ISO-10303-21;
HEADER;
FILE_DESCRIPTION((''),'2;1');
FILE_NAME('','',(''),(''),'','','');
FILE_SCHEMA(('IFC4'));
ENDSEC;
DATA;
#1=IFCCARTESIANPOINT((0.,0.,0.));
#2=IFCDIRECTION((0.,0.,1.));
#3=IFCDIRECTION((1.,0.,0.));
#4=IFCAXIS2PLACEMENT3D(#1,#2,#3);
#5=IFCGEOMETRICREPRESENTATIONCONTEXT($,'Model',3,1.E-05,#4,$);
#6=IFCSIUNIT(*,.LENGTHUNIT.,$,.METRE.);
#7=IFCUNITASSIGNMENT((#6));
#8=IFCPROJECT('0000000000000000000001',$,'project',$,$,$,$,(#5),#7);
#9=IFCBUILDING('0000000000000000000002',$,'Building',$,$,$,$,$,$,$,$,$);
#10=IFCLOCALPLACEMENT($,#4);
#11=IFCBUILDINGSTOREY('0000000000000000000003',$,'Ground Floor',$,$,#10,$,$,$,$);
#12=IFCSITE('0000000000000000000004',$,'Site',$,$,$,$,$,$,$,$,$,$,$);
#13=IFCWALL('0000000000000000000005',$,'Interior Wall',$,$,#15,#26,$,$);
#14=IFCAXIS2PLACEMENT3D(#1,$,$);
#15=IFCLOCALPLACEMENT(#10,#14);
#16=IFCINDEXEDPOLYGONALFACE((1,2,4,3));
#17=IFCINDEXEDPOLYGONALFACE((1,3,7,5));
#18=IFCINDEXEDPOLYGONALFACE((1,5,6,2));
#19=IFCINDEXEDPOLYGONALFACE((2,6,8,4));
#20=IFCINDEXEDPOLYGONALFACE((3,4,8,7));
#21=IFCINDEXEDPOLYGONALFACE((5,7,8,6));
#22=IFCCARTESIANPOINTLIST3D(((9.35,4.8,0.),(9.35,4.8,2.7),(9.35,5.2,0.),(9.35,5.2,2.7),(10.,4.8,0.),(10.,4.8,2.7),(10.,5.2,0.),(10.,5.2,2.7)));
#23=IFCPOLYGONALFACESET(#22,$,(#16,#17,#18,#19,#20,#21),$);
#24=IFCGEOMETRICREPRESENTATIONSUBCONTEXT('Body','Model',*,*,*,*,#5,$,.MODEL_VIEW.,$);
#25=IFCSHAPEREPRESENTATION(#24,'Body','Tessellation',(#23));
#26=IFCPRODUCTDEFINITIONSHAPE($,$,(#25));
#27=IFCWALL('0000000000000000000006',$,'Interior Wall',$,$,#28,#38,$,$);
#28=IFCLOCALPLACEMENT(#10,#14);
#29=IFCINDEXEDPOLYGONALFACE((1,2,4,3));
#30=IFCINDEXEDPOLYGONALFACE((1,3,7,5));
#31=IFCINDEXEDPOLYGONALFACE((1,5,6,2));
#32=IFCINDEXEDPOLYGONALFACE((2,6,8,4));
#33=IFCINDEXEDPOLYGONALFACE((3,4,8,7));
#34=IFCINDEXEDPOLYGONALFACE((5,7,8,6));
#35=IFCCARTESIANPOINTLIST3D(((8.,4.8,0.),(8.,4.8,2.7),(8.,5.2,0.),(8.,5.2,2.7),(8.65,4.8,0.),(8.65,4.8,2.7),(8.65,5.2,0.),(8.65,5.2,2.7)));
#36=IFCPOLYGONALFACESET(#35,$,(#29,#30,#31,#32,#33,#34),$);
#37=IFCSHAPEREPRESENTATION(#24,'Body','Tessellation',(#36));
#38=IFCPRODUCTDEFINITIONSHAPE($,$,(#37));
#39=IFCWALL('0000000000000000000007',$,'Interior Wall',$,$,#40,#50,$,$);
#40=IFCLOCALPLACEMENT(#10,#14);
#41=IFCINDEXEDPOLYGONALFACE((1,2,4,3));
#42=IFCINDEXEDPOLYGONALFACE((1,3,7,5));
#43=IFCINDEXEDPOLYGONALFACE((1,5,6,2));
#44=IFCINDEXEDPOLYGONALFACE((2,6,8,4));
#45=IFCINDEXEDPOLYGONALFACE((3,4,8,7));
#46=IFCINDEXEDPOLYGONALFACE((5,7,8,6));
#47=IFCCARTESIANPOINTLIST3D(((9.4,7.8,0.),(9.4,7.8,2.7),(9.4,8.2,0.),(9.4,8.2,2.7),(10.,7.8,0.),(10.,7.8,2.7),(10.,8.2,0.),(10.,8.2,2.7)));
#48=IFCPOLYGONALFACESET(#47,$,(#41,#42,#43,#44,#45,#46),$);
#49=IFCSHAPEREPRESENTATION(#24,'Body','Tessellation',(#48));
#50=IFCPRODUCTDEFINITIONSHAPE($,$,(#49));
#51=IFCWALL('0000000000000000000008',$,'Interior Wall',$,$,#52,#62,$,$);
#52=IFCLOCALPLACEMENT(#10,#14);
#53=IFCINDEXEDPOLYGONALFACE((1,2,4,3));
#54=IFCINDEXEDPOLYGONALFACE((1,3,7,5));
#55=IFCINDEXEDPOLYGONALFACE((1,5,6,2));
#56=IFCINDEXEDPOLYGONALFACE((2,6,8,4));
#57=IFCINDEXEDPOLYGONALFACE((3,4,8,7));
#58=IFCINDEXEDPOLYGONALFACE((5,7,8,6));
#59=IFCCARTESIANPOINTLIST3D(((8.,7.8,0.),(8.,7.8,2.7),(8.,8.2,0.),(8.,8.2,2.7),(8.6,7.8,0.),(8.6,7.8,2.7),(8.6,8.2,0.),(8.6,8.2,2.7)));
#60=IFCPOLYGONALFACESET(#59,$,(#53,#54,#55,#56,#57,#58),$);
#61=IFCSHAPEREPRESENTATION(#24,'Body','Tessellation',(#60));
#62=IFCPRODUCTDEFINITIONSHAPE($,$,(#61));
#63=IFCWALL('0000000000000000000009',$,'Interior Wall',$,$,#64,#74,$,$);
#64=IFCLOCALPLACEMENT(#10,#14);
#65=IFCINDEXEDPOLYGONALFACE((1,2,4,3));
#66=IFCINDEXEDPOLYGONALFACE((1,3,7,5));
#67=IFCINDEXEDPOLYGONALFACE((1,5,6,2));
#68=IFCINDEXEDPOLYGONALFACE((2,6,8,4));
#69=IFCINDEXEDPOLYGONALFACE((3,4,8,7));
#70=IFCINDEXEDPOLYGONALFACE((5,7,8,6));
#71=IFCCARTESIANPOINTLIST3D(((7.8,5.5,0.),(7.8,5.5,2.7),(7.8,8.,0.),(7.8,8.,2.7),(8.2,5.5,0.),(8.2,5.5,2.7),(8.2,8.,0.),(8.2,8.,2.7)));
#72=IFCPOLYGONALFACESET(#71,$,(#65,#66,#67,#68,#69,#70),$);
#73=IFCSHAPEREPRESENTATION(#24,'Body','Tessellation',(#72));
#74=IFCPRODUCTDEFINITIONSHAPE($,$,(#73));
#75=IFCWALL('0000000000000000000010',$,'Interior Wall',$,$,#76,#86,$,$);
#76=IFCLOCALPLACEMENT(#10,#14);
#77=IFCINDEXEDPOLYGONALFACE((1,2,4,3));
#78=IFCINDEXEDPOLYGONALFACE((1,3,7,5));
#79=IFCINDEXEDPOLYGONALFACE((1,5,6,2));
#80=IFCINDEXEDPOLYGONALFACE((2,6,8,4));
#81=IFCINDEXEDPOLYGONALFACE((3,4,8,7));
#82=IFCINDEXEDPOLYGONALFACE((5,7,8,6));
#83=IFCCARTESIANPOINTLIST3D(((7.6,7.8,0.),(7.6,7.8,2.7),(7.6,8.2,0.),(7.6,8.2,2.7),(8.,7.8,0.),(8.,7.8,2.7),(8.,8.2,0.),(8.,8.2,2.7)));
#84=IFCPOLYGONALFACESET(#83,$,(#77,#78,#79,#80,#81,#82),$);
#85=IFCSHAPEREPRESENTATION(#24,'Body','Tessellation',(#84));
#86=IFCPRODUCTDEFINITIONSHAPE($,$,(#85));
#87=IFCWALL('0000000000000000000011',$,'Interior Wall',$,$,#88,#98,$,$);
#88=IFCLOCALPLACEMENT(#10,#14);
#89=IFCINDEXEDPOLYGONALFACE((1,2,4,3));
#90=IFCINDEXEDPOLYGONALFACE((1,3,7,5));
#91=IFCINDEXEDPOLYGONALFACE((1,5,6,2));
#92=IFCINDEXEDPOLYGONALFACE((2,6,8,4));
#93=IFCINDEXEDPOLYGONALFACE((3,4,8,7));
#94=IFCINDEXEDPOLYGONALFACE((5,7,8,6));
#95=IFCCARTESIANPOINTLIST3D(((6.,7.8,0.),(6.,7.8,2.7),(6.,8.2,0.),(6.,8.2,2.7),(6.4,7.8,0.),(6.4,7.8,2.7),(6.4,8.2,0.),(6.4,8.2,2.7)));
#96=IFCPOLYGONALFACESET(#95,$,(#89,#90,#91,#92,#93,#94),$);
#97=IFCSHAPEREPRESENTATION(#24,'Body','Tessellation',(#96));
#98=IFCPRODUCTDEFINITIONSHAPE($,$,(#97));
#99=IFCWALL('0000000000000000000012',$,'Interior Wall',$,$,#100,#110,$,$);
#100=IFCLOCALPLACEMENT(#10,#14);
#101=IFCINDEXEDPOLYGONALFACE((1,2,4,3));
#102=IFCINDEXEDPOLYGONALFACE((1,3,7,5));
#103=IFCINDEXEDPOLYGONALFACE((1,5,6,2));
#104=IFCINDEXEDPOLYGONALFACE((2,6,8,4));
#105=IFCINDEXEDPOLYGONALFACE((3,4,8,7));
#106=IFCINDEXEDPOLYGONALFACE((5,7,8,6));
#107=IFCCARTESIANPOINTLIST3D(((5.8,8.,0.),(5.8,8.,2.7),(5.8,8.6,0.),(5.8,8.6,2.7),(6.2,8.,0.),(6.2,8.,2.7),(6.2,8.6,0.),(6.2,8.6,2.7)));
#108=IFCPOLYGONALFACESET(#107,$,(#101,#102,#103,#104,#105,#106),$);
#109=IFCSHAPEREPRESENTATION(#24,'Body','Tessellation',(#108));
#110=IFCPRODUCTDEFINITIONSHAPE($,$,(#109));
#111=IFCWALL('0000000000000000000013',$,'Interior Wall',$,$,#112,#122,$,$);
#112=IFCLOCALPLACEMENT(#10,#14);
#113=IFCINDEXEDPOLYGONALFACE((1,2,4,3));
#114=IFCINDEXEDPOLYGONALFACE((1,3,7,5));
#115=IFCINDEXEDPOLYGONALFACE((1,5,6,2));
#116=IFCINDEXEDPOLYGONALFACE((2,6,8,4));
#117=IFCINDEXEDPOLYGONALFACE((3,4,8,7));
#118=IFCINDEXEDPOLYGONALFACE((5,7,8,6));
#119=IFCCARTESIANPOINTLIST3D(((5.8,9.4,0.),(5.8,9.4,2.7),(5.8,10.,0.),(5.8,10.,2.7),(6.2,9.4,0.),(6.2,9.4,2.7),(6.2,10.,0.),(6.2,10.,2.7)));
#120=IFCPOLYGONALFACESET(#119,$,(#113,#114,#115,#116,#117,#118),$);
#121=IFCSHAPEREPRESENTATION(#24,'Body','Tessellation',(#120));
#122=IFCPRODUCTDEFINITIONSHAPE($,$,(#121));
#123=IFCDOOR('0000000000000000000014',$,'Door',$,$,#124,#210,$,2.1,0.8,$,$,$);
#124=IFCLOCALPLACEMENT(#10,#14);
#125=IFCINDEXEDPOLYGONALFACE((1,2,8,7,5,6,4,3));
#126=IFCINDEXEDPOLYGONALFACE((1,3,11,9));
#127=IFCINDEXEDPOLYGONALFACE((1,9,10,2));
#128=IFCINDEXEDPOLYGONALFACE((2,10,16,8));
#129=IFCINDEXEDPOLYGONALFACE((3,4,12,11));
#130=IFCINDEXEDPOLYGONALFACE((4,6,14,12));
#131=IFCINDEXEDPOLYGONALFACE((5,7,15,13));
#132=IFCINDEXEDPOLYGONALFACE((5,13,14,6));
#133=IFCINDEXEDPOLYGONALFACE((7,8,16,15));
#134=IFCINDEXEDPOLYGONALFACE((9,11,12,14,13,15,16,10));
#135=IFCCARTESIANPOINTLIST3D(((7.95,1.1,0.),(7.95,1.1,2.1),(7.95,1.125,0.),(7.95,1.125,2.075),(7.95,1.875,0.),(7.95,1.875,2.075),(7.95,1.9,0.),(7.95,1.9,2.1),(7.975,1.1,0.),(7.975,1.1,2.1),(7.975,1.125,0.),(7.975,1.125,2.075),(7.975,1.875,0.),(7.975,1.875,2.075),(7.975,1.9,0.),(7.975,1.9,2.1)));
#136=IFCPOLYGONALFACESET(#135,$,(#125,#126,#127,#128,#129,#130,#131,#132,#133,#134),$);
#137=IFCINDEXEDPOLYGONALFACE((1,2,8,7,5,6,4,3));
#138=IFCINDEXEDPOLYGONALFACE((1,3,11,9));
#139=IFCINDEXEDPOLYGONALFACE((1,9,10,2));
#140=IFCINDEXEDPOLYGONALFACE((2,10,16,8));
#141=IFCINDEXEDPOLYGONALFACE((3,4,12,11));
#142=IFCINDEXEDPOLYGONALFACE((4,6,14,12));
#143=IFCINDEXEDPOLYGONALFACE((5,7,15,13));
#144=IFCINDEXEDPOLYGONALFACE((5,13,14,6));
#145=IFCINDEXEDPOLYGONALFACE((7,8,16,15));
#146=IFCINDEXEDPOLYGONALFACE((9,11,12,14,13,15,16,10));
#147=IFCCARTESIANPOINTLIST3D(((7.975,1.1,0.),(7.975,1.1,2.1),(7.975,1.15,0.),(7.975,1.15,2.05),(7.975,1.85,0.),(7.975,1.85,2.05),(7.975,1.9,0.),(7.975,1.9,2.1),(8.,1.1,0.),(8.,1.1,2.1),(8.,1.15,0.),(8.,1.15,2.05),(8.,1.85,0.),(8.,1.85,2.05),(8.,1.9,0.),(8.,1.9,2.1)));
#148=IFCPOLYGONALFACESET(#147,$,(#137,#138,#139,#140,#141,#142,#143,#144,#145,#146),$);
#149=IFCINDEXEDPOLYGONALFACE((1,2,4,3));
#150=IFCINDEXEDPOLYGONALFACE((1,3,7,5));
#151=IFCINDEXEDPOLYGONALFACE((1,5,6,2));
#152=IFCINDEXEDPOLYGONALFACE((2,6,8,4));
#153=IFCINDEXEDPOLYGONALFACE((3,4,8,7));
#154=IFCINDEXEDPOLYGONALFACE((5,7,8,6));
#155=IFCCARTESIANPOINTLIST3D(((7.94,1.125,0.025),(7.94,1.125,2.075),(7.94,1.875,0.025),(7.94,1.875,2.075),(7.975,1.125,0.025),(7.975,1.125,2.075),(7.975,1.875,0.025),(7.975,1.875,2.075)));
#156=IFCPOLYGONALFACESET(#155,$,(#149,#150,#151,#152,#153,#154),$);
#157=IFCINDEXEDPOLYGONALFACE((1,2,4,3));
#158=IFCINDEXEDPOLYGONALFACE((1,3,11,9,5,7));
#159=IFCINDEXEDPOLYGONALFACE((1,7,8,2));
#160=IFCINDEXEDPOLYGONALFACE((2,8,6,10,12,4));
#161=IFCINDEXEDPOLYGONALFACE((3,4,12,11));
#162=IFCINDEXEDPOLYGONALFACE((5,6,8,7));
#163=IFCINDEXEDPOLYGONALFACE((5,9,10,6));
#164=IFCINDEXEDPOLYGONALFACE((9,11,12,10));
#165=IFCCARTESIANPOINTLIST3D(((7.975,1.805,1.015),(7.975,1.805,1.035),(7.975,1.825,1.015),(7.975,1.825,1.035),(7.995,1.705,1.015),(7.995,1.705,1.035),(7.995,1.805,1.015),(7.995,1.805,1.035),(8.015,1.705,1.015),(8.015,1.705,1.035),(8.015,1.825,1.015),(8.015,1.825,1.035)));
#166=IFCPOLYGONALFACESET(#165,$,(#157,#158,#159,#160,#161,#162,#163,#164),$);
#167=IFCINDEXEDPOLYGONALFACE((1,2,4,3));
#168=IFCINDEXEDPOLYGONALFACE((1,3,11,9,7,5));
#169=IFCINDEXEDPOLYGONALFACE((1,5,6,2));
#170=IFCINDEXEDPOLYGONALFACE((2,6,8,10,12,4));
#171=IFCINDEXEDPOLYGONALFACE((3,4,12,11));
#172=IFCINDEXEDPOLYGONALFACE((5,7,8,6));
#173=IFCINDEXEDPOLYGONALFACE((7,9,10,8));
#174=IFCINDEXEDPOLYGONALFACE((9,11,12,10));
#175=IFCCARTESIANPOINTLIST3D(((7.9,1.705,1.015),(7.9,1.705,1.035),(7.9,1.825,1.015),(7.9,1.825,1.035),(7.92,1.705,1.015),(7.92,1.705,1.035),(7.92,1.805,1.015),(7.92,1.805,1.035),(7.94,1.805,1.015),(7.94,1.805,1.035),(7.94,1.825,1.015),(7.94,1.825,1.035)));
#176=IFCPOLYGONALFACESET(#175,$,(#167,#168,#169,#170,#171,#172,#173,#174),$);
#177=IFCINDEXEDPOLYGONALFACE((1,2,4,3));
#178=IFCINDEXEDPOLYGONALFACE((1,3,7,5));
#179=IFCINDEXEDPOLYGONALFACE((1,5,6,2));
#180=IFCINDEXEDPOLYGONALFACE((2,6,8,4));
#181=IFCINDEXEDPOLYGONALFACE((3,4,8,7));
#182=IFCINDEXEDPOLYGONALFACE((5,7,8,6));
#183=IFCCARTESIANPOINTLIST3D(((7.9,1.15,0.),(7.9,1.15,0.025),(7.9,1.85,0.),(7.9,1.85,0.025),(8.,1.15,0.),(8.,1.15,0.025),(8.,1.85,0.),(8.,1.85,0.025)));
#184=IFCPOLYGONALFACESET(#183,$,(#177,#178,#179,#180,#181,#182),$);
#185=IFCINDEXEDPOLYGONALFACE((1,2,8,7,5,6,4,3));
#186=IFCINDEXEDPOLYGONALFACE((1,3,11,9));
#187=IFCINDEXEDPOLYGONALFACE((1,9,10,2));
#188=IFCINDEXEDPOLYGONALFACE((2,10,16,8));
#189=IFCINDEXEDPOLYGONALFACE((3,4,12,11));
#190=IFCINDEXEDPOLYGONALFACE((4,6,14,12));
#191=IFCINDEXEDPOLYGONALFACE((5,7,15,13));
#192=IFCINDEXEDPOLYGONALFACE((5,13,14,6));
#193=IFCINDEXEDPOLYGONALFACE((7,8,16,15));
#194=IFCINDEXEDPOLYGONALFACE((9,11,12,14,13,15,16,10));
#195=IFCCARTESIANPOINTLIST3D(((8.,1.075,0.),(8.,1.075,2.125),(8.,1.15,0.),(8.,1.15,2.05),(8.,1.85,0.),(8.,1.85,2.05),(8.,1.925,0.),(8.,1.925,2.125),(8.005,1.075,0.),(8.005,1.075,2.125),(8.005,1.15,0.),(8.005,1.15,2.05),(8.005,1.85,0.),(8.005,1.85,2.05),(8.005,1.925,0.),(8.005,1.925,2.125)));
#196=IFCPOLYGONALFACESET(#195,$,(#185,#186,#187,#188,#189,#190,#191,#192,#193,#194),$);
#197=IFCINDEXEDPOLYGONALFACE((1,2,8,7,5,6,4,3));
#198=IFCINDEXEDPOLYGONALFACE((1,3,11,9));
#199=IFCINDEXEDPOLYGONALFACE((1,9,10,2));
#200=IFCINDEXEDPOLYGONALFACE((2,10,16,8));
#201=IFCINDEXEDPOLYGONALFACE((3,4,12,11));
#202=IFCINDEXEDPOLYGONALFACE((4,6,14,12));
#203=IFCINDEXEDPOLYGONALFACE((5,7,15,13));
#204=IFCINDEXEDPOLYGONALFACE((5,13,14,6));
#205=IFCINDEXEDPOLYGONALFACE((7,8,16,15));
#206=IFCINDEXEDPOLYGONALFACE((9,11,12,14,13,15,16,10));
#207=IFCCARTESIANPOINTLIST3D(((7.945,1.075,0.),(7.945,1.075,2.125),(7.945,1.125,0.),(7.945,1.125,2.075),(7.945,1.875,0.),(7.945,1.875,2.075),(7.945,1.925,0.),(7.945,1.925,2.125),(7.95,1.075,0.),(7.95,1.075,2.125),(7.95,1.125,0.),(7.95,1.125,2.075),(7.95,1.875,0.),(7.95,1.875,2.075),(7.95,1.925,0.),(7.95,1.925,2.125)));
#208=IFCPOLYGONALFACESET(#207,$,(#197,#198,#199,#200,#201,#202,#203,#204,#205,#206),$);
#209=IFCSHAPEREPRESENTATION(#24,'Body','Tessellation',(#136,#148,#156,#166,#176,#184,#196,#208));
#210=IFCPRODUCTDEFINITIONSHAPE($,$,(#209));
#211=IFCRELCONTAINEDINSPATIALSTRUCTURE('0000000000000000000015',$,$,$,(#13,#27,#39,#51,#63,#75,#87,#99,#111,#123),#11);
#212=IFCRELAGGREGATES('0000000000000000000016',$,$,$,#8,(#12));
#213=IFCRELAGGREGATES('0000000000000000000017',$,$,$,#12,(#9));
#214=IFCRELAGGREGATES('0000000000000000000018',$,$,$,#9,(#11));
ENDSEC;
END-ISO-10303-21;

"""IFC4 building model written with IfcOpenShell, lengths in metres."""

from ifc_helpers import new_model, si_unit, frame, origin_with_axes, place, context, subcontext, project, spatial, line, indexed_curve, outline, extrude, element, save


model = new_model("IFC4")

# Units and contexts
model_context = context("Model", 3, precision=1e-05, world=origin_with_axes())
body_context = subcontext(model_context, "Body", "Model", "MODEL_VIEW")
ifc_project = project(units=[si_unit("LENGTHUNIT", "METRE")], contexts=[model_context])

# Site, building, storey
site = spatial("IfcSite", under=ifc_project, Name="Site")
building = spatial("IfcBuilding", under=site, Name="Building")
storey_placement = place(None, origin_with_axes())
storey = spatial("IfcBuildingStorey", under=building, at=storey_placement, Name="Ground Floor")

# Walls
for number, where, z_axis, x_axis, name in (
    (1, (10.0, 5.0, 0.0), (0.0, 0.0, 1.0), (-1.0, 0.0, 0.0), "Interior Wall"),
    (2, (8.65, 5.0, 0.0), (0.0, 0.0, 1.0), (-1.0, 0.0, 0.0), "Interior Wall"),
):
    element("IfcWall", number, at=place(storey_placement, frame(where, z_axis=z_axis, x_axis=x_axis)), inside=storey, Name=name, context=body_context, shape_type="SweptSolid", body=[
        extrude(outline(indexed_curve([(0.0, 0.0), (0.0, 0.4), (0.65, 0.4), (0.65, 0.0), (0.0, 0.0)], self_intersect=False)), frame((0.0, -0.2, 0.0), z_axis=(0.0, 0.0, 1.0), x_axis=(1.0, 0.0, 0.0)), (0.0, 0.0, 1.0), 2.7),
    ])
for number, where, z_axis, x_axis, name in (
    (3, (10.0, 8.0, 0.0), (0.0, 0.0, 1.0), (-1.0, 0.0, 0.0), "Interior Wall"),
    (4, (8.6, 8.0, 0.0), (0.0, 0.0, 1.0), (-1.0, 0.0, 0.0), "Interior Wall"),
):
    element("IfcWall", number, at=place(storey_placement, frame(where, z_axis=z_axis, x_axis=x_axis)), inside=storey, Name=name, context=body_context, shape_type="SweptSolid", body=[
        extrude(outline(indexed_curve([(0.0, 0.0), (0.0, 0.4), (0.6, 0.4), (0.6, 0.0), (0.0, 0.0)], self_intersect=False)), frame((0.0, -0.2, 0.0), z_axis=(0.0, 0.0, 1.0), x_axis=(1.0, 0.0, 0.0)), (0.0, 0.0, 1.0), 2.7),
    ])
wall_1_placement = place(storey_placement, frame((8.0, 8.0, 0.0), z_axis=(0.0, 0.0, 1.0), x_axis=(0.0, -1.0, 0.0)))
element("IfcWall", 5, at=wall_1_placement, inside=storey, Name="Interior Wall", context=body_context, shape_type="SweptSolid", body=[
    extrude(outline(indexed_curve([(0.0, 0.0), (0.0, 0.4), (2.5, 0.4), (2.5, 0.0), (0.0, 0.0)], self_intersect=False)), frame((0.0, -0.2, 0.0), z_axis=(0.0, 0.0, 1.0), x_axis=(1.0, 0.0, 0.0)), (0.0, 0.0, 1.0), 2.7),
])
for number, where, z_axis, x_axis, name in (
    (6, (8.0, 8.0, 0.0), (0.0, 0.0, 1.0), (-1.0, 0.0, 0.0), "Interior Wall"),
    (7, (6.4, 8.0, 0.0), (0.0, 0.0, 1.0), (-1.0, 0.0, 0.0), "Interior Wall"),
):
    element("IfcWall", number, at=place(storey_placement, frame(where, z_axis=z_axis, x_axis=x_axis)), inside=storey, Name=name, context=body_context, shape_type="SweptSolid", body=[
        extrude(outline(indexed_curve([(0.0, 0.0), (0.0, 0.4), (0.4, 0.4), (0.4, 0.0), (0.0, 0.0)], self_intersect=False)), frame((0.0, -0.2, 0.0), z_axis=(0.0, 0.0, 1.0), x_axis=(1.0, 0.0, 0.0)), (0.0, 0.0, 1.0), 2.7),
    ])
for number, where, z_axis, x_axis, name in (
    (8, (6.0, 8.0, 0.0), (0.0, 0.0, 1.0), (0.0, 1.0, 0.0), "Interior Wall"),
    (9, (6.0, 9.4, 0.0), (0.0, 0.0, 1.0), (0.0, 1.0, 0.0), "Interior Wall"),
):
    element("IfcWall", number, at=place(storey_placement, frame(where, z_axis=z_axis, x_axis=x_axis)), inside=storey, Name=name, context=body_context, shape_type="SweptSolid", body=[
        extrude(outline(indexed_curve([(0.0, 0.0), (0.0, 0.4), (0.6, 0.4), (0.6, 0.0), (0.0, 0.0)], self_intersect=False)), frame((0.0, -0.2, 0.0), z_axis=(0.0, 0.0, 1.0), x_axis=(1.0, 0.0, 0.0)), (0.0, 0.0, 1.0), 2.7),
    ])

# Door
door_1_placement = place(storey_placement, frame((8.0, 1.1, 0.0), z_axis=(0.0, 0.0, 1.0), x_axis=(0.0, 1.0, 0.0)))
element("IfcDoor", 10, at=door_1_placement, inside=storey, Name="Door", OverallHeight=2.1, OverallWidth=0.8, context=body_context, shape_type="SweptSolid", body=[
    extrude(outline(indexed_curve([(0.0, 0.0), (0.0, 2.1), (0.8, 2.1), (0.8, 0.0), (0.775, 0.0), (0.775, 2.075), (0.025, 2.075), (0.025, 0.0)], segments=[line(1, 2, 3, 4, 5, 6, 7, 8, 1)])), frame((0.0, 0.025, 0.0), z_axis=(0.0, -1.0, 0.0), x_axis=(1.0, 0.0, 0.0)), (0.0, 0.0, -1.0), 0.025),
    extrude(outline(indexed_curve([(0.0, 0.0), (0.0, 2.1), (0.8, 2.1), (0.8, 0.0), (0.75, 0.0), (0.75, 2.05), (0.05, 2.05), (0.05, 0.0)], segments=[line(1, 2, 3, 4, 5, 6, 7, 8, 1)])), frame((0.0, 0.0, 0.0), z_axis=(0.0, -1.0, 0.0), x_axis=(1.0, 0.0, 0.0)), (0.0, 0.0, -1.0), 0.025),
    extrude(outline(indexed_curve([(0.0, 0.0), (0.75, 0.0), (0.75, 0.035), (0.0, 0.035)], segments=[line(1, 2, 3, 4, 1)])), frame((0.025, 0.025, 0.025), z_axis=(0.0, 0.0, 1.0), x_axis=(1.0, 0.0, 0.0)), (0.0, 0.0, 1.0), 2.05),
    extrude(outline(indexed_curve([(0.0, 0.0), (0.0, -0.04), (-0.12, -0.04), (-0.12, -0.02), (-0.02, -0.02), (-0.02, 0.0)], segments=[line(1, 2, 3, 4, 5, 6, 1)])), frame((0.725, 0.025, 1.015), z_axis=(0.0, 0.0, 1.0), x_axis=(1.0, 0.0, 0.0)), (0.0, 0.0, 1.0), 0.02),
    extrude(outline(indexed_curve([(0.0, 0.0), (0.0, 0.04), (-0.12, 0.04), (-0.12, 0.02), (-0.02, 0.02), (-0.02, 0.0)], segments=[line(1, 2, 3, 4, 5, 6, 1)])), frame((0.725, 0.06, 1.015), z_axis=(0.0, 0.0, 1.0), x_axis=(1.0, 0.0, 0.0)), (0.0, 0.0, 1.0), 0.02),
    extrude(outline(indexed_curve([(0.0, 0.0), (0.7, 0.0), (0.7, 0.1), (0.0, 0.1)], segments=[line(1, 2, 3, 4, 1)])), frame((0.05, 0.0, 0.0), z_axis=(0.0, 0.0, 1.0), x_axis=(1.0, 0.0, 0.0)), (0.0, 0.0, 1.0), 0.025),
    extrude(outline(indexed_curve([(0.0, 0.0), (0.0, 2.125), (0.85, 2.125), (0.85, 0.0), (0.775, 0.0), (0.775, 2.05), (0.075, 2.05), (0.075, 0.0)], segments=[line(1, 2, 3, 4, 5, 6, 7, 8, 1)])), frame((-0.025, -0.005, 0.0), z_axis=(0.0, -1.0, 0.0), x_axis=(1.0, 0.0, 0.0)), (0.0, 0.0, -1.0), 0.005),
    extrude(outline(indexed_curve([(0.0, 0.0), (0.0, 2.125), (0.85, 2.125), (0.85, 0.0), (0.8, 0.0), (0.8, 2.075), (0.05, 2.075), (0.05, 0.0)], segments=[line(1, 2, 3, 4, 5, 6, 7, 8, 1)])), frame((-0.025, 0.05, 0.0), z_axis=(0.0, -1.0, 0.0), x_axis=(1.0, 0.0, 0.0)), (0.0, 0.0, -1.0), 0.005),
])

save(model, "model.ifc")
